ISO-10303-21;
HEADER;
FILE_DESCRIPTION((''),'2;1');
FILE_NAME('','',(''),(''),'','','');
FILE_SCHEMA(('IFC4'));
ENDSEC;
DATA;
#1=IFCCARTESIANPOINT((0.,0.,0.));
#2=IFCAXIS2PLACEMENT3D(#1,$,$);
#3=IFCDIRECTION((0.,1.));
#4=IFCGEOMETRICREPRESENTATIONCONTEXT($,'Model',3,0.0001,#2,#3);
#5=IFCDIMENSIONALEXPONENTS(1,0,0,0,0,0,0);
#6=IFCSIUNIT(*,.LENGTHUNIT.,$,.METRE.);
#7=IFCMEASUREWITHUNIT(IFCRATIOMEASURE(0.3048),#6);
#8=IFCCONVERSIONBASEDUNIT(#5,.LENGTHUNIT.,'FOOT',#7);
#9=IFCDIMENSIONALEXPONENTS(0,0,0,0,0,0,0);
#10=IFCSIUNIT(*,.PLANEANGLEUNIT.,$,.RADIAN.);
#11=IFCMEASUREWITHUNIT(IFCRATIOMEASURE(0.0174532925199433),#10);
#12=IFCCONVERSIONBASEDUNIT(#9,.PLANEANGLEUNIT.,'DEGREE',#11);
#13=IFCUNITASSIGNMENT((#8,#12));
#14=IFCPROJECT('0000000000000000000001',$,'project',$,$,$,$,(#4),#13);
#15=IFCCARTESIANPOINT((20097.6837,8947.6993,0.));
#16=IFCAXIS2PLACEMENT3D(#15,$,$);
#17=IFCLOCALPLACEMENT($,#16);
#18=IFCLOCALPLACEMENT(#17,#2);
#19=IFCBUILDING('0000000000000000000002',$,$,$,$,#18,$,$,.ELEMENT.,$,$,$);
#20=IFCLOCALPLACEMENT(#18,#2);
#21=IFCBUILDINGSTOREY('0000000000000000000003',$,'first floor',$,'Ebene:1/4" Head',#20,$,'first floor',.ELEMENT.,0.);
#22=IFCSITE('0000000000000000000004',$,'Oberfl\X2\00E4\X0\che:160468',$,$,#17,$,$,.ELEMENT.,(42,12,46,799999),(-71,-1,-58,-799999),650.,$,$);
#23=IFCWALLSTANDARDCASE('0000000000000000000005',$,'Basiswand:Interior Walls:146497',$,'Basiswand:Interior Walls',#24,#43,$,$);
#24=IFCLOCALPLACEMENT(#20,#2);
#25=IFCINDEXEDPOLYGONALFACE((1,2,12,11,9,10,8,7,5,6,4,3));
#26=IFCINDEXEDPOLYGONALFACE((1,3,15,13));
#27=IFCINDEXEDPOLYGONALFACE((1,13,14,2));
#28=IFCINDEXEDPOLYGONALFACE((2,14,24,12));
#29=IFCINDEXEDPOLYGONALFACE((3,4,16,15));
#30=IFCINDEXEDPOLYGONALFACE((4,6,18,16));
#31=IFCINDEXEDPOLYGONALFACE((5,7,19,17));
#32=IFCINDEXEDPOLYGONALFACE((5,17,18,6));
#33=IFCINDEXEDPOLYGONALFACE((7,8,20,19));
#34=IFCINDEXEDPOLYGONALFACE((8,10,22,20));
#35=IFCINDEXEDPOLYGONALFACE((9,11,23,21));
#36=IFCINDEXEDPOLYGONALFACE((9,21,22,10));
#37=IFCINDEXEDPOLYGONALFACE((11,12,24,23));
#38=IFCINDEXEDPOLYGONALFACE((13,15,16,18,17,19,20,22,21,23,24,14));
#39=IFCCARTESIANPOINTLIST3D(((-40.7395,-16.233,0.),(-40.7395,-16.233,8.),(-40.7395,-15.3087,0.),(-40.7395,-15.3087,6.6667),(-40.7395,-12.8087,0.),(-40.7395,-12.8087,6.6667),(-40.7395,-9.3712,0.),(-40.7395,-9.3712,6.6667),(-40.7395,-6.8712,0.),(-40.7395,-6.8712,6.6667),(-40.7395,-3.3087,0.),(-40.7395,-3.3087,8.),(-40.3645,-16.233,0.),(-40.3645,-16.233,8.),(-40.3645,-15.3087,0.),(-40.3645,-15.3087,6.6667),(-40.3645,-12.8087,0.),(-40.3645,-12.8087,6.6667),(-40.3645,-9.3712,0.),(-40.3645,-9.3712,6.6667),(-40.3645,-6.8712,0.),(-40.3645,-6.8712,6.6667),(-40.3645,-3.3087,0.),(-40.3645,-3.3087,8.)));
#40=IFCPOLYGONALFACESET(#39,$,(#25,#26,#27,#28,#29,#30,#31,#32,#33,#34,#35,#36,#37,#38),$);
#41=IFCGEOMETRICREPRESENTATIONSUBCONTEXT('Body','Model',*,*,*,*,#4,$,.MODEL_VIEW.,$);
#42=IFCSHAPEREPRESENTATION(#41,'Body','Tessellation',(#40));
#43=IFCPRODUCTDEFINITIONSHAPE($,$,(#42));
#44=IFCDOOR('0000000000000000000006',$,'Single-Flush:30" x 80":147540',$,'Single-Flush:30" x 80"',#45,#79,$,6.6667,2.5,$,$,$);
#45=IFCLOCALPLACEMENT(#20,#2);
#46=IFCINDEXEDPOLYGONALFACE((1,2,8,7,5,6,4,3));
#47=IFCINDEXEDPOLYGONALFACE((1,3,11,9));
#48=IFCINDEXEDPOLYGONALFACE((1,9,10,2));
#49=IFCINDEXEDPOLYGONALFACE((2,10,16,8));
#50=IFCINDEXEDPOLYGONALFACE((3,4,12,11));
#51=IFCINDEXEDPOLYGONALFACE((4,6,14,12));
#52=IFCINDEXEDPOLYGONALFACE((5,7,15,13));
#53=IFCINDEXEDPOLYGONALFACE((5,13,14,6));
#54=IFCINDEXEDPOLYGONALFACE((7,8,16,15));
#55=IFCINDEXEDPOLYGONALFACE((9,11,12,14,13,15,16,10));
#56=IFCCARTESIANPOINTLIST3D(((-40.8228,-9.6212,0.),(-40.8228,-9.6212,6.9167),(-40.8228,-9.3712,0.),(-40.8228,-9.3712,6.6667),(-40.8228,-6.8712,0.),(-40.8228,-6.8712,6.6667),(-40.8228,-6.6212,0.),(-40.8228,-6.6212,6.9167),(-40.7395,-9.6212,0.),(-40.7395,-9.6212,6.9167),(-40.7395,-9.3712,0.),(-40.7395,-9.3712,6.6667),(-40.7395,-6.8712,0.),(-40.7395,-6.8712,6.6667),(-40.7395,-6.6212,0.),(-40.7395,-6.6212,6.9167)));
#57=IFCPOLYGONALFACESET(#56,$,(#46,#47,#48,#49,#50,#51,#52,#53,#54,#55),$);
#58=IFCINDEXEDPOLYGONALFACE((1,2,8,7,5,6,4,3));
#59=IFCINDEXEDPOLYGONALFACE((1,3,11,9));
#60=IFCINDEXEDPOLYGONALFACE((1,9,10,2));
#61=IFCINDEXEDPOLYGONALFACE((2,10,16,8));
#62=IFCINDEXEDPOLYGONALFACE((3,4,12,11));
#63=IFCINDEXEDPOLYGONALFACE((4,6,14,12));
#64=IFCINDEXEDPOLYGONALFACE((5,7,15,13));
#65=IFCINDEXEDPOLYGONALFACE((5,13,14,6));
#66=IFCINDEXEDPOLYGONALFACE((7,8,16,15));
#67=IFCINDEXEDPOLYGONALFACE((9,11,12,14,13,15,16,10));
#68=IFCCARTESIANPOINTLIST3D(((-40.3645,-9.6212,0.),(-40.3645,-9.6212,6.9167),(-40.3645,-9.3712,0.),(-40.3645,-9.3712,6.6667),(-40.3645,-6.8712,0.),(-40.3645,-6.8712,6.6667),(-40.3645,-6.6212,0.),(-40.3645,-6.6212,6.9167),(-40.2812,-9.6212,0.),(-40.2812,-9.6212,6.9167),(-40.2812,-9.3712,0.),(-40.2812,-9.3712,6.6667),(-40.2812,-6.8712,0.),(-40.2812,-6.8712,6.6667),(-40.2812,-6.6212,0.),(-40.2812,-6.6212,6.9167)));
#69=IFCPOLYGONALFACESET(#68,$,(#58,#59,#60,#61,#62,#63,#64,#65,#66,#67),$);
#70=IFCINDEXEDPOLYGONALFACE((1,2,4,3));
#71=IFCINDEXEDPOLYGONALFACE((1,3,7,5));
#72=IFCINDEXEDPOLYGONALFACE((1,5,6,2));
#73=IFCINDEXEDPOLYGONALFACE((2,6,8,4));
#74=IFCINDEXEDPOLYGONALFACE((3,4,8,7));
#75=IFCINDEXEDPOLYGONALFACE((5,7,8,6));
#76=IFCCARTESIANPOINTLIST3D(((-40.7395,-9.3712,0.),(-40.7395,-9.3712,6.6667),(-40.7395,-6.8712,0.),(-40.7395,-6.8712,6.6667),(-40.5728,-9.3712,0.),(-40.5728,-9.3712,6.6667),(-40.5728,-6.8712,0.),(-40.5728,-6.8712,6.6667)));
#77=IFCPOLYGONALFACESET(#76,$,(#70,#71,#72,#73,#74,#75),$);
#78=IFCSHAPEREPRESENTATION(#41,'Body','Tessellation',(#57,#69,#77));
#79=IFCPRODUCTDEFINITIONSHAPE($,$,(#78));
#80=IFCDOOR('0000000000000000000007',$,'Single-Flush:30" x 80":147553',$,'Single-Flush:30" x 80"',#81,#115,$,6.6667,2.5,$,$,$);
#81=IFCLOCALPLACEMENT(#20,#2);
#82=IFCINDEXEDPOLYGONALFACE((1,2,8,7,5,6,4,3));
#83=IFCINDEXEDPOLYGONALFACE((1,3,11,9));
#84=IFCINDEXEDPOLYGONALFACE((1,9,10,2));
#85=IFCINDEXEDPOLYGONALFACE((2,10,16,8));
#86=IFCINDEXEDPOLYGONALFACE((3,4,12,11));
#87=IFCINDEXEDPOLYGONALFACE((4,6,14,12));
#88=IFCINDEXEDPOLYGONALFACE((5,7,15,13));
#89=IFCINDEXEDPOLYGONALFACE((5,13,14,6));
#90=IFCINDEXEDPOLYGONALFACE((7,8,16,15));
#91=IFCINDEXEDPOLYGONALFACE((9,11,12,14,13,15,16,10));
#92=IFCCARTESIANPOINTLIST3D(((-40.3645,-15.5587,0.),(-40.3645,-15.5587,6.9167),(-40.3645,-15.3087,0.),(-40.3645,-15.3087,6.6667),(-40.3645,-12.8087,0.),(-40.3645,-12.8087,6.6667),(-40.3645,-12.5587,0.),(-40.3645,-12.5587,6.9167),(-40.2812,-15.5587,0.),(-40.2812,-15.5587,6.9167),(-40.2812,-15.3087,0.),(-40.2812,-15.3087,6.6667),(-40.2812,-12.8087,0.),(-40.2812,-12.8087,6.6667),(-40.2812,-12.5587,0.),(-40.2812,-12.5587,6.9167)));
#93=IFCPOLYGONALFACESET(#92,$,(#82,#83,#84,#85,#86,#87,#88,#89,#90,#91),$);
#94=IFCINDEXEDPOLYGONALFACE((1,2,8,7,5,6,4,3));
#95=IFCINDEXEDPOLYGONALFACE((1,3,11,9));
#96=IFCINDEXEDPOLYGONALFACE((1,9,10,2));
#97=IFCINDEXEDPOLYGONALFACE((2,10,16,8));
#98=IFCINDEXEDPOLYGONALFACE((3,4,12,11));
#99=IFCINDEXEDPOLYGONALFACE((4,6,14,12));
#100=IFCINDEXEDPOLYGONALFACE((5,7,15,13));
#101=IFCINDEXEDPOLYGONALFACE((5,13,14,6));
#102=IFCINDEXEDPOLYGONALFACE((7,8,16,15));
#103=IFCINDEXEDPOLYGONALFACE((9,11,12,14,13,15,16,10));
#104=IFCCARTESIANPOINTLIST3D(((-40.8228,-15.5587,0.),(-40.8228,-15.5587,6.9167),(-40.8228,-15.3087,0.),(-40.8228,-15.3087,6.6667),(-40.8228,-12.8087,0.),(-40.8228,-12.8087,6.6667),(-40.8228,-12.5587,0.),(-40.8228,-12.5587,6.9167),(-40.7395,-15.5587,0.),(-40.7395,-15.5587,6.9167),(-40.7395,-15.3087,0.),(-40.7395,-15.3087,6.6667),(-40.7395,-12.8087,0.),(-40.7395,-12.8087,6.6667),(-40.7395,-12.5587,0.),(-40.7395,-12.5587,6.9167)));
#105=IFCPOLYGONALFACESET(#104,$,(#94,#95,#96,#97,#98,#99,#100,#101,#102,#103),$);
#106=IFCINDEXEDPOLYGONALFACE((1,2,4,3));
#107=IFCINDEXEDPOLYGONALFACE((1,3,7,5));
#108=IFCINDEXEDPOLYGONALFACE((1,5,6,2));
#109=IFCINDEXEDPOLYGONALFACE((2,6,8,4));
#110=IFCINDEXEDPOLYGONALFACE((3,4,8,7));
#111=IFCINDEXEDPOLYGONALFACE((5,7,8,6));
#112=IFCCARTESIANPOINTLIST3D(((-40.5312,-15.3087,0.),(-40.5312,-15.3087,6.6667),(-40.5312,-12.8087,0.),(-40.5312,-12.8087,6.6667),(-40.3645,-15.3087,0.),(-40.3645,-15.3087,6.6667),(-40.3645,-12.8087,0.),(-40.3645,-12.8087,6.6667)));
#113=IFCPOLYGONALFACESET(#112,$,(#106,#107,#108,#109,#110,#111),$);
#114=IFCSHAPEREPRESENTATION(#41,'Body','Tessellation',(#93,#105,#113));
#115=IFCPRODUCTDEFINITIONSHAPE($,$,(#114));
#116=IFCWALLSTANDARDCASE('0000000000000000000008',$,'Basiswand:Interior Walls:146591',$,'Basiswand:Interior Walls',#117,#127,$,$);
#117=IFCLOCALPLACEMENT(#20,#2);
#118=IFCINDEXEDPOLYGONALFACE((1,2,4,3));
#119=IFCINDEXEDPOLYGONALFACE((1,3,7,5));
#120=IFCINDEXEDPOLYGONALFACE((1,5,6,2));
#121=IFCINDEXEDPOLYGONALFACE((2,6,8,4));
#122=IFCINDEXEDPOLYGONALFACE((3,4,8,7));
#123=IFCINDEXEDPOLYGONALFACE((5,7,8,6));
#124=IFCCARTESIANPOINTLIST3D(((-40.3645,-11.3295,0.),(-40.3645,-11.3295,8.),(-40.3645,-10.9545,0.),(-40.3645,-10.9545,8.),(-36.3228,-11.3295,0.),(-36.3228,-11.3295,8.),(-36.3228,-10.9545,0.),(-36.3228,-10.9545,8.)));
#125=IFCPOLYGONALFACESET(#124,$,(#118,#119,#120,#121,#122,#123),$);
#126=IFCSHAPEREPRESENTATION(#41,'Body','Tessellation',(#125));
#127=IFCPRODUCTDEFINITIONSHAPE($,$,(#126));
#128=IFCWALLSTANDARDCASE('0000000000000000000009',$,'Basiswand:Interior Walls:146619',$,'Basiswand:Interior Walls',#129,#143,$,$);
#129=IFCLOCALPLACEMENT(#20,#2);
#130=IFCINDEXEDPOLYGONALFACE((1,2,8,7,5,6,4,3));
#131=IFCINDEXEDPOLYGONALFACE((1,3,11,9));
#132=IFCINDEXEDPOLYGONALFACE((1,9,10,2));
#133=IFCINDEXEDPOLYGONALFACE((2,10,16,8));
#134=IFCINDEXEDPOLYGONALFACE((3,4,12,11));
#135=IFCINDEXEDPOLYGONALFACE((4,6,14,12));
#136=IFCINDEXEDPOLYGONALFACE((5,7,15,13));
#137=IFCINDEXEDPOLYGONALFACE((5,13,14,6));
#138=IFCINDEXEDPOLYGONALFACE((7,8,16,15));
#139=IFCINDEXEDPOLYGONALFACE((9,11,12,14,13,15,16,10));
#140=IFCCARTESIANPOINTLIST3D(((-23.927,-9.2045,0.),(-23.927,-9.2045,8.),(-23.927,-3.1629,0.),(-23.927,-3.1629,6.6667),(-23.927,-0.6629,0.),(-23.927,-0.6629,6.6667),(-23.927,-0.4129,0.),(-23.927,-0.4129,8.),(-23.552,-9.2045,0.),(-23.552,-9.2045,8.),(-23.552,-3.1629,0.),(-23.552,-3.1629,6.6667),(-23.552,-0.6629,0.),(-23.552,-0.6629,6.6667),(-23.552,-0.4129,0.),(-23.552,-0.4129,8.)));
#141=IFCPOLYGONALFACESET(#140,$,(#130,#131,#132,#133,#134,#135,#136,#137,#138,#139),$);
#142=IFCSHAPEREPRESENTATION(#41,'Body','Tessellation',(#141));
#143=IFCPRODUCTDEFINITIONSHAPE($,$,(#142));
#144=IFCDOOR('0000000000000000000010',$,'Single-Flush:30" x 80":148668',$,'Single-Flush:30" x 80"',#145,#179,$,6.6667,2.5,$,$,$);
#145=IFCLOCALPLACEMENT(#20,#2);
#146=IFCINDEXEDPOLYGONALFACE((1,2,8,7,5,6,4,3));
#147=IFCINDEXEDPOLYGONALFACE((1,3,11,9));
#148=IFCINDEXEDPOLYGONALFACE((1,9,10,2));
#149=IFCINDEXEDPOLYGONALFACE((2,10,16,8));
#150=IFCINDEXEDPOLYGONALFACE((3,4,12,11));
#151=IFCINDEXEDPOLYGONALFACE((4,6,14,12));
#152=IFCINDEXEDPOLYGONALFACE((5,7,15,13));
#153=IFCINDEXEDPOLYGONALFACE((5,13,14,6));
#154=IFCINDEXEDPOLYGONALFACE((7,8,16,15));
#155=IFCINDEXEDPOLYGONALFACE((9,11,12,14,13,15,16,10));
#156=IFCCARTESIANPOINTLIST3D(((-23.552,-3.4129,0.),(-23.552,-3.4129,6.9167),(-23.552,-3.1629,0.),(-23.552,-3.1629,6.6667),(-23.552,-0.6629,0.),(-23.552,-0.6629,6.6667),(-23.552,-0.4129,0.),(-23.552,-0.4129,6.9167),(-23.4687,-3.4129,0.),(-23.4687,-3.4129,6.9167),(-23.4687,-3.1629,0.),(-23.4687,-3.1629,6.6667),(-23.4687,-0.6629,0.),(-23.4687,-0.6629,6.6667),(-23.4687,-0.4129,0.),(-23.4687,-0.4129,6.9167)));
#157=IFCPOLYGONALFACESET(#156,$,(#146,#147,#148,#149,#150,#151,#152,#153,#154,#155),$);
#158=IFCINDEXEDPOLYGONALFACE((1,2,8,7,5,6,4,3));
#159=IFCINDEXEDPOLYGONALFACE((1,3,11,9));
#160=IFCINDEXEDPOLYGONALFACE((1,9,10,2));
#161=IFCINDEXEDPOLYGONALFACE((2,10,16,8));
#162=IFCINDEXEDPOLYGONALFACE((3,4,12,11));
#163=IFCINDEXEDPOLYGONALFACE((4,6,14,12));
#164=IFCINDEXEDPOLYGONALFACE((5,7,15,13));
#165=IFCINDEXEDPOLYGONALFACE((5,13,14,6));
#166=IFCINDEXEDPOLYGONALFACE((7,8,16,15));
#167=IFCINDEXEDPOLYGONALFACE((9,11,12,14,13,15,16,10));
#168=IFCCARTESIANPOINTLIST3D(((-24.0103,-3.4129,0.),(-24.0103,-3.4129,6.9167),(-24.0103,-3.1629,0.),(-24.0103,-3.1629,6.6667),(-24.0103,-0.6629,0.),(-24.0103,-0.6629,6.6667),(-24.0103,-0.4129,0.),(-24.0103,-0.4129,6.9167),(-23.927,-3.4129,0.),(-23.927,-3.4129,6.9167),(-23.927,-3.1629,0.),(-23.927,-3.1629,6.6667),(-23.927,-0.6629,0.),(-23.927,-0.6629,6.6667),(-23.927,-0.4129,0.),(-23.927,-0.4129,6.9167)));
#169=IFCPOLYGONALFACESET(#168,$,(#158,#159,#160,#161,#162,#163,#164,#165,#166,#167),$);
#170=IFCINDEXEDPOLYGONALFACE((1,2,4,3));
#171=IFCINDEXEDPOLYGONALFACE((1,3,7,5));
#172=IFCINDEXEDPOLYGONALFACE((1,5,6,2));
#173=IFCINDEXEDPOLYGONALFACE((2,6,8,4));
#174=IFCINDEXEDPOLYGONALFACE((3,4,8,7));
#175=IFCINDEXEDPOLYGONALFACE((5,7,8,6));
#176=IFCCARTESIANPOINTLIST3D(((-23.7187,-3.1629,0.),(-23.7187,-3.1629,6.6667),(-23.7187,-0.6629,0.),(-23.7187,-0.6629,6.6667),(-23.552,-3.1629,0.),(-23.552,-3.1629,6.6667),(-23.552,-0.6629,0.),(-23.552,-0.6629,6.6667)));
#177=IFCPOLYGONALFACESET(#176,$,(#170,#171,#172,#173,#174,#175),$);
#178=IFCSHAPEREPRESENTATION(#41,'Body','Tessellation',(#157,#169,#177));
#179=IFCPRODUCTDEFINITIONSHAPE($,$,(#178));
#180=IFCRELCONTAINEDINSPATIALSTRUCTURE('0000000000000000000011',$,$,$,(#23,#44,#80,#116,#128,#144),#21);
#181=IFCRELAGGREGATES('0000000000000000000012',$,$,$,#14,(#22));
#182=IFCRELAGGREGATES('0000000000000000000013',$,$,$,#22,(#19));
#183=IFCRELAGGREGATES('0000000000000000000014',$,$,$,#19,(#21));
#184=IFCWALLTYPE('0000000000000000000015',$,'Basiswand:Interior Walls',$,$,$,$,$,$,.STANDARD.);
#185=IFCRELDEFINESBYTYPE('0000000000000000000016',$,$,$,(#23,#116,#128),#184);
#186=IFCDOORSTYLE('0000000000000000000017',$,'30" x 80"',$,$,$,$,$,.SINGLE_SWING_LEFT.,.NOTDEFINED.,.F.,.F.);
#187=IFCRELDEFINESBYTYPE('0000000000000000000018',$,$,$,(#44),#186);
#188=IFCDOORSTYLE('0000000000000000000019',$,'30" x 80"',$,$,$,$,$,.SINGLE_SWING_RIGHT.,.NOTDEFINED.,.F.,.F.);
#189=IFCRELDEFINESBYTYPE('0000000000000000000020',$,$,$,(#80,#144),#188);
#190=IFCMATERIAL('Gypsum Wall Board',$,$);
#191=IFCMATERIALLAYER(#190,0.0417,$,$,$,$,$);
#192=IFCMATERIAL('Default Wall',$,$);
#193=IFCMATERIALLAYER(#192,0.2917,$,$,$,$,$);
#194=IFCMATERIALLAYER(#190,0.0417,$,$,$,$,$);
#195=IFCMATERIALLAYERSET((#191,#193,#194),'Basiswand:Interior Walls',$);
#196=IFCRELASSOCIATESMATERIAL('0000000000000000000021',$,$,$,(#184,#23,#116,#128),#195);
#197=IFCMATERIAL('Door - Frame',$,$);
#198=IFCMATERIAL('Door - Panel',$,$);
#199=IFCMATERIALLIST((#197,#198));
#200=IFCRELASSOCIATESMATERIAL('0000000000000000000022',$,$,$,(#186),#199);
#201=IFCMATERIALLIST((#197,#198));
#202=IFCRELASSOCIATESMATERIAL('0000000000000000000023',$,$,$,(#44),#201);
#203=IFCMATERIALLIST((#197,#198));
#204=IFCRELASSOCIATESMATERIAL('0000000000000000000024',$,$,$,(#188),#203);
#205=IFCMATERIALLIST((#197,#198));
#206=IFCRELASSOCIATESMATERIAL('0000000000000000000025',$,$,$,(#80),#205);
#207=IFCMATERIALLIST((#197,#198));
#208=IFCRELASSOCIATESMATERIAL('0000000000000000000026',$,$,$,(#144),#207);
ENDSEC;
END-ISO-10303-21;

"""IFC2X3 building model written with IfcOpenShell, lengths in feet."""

from ifc_helpers import new_model, entity, si_unit, converted_unit, direction, frame, frame_2d, origin, origin_2d_with_axis, place, context, subcontext, project, spatial, polyline, rectangle, outline, extrude, source, transform, mapped, material, material_list, layer, layer_set, layer_usage, type_object, type_shapes, element, fill, save


model = new_model("IFC2X3")

# Units and contexts
model_context = context("Model", 3, precision=0.0001, world=origin(), true_north=direction((0.0, 1.0)))
body_context = subcontext(model_context, "Body", "Model", "MODEL_VIEW")
ifc_project = project(units=[converted_unit("LENGTHUNIT", "FOOT", entity("IfcRatioMeasure", 0.3048), si_unit("LENGTHUNIT", "METRE"), dimensions=[1, 0, 0, 0, 0, 0, 0]), converted_unit("PLANEANGLEUNIT", "DEGREE", entity("IfcRatioMeasure", 0.0174532925199433), si_unit("PLANEANGLEUNIT", "RADIAN"), dimensions=[0, 0, 0, 0, 0, 0, 0])], contexts=[model_context])

# Site, building, storey
site_placement = place(None, frame((20097.6837, 8947.6993, 0.0)))
site = spatial("IfcSite", under=ifc_project, at=site_placement, Name="Oberfläche:160468", CompositionType="ELEMENT", RefLatitude=(42, 12, 46, 799999), RefLongitude=(-71, -1, -58, -799999), RefElevation=650.0)
building_placement = place(site_placement, origin())
building = spatial("IfcBuilding", under=site, at=building_placement, CompositionType="ELEMENT")
storey_placement = place(building_placement, origin())
storey = spatial("IfcBuildingStorey", under=building, at=storey_placement, Name="first floor", ObjectType="Ebene:1/4\" Head", LongName="first floor", CompositionType="ELEMENT", Elevation=0.0)

# Shared definitions
ifc_material_1 = material(Name="Gypsum Wall Board")

# Shared definitions
ifc_material_2 = material(Name="Door - Frame")

# Shared definitions
ifc_material_3 = material(Name="Door - Panel")

# Wall, openings, doors
ifc_layer_1 = layer(ifc_material_1, 0.0417)
ifc_material_4 = material(Name="Default Wall")
ifc_layer_2 = layer(ifc_material_4, 0.2917)
ifc_layer_3 = layer(ifc_material_1, 0.0417)
ifc_layer_set_1 = layer_set([ifc_layer_1, ifc_layer_2, ifc_layer_3], Name="Basiswand:Interior Walls")
ifc_layer_usage_1 = layer_usage(ifc_layer_set_1, "AXIS2", "NEGATIVE", 0.1875)
wall_type_1 = type_object("IfcWallType", Name="Basiswand:Interior Walls", PredefinedType="STANDARD", material=ifc_layer_set_1)
wall_1_placement = place(storey_placement, frame((-40.552, -3.3087, 0.0), z_axis=(0.0, 0.0, 1.0), x_axis=(0.0, -1.0, 0.0)))
wall_1 = element("IfcWallStandardCase", 1, at=wall_1_placement, inside=storey, type_object=wall_type_1, material=ifc_layer_usage_1, Name="Basiswand:Interior Walls:146497", ObjectType="Basiswand:Interior Walls", context=body_context, shape_type="SweptSolid", body=[
    extrude(rectangle(XDim=12.9243, YDim=0.375, at=frame_2d((6.4621, 0.0), x_axis=(-1.0, 0.0))), origin(), (0.0, 0.0, 1.0), 8.0),
])
opening_1_placement = place(wall_1_placement, frame((6.0625, 0.1875, 0.0)))
opening_1 = element("IfcOpeningElement", 2, at=opening_1_placement, cuts=wall_1, ObjectType="Opening", context=body_context, shape_type="SweptSolid", body=[
    extrude(rectangle(XDim=2.5, YDim=6.6667, at=frame_2d((3.3333, 1.25), x_axis=(0.0, -1.0))), frame((0.0, 0.0, 0.0), z_axis=(0.0, -1.0, 0.0), x_axis=(0.0, 0.0, 1.0)), (0.0, 0.0, 1.0), 0.375),
])
opening_2_placement = place(wall_1_placement, frame((9.5, -0.1875, 0.0)))
opening_2 = element("IfcOpeningElement", 3, at=opening_2_placement, cuts=wall_1, ObjectType="Opening", context=body_context, shape_type="SweptSolid", body=[
    extrude(rectangle(XDim=2.5, YDim=6.6667, at=frame_2d((3.3333, 1.25), x_axis=(0.0, 1.0))), frame((0.0, 0.0, 0.0), z_axis=(0.0, 1.0, 0.0), x_axis=(0.0, 0.0, 1.0)), (0.0, 0.0, 1.0), 0.375),
])
ifc_material_list_1 = material_list([ifc_material_2, ifc_material_3])
ifc_material_list_2 = material_list([ifc_material_2, ifc_material_3])
door_style_1 = type_object("IfcDoorStyle", Name="30\" x 80\"", ConstructionType="NOTDEFINED", OperationType="SINGLE_SWING_LEFT", ParameterTakesPrecedence=False, Sizeable=False, material=ifc_material_list_2)
shared_shape_1 = source(origin(), body_context, "Body", "SweptSolid", [
    extrude(outline(polyline([(-1.5, -3.5208), (1.5, -3.5208), (1.5, 3.3958), (1.25, 3.3958), (1.25, -3.2708), (-1.25, -3.2708), (-1.25, 3.3958), (-1.5, 3.3958), (-1.5, -3.5208)])), frame((1.25, 0.4583, 3.3958), z_axis=(0.0, -1.0, 0.0), x_axis=(-1.0, 0.0, 0.0)), (0.0, 0.0, 1.0), 0.0833),
    extrude(outline(polyline([(-3.5208, -1.5), (3.3958, -1.5), (3.3958, -1.25), (-3.2708, -1.25), (-3.2708, 1.25), (3.3958, 1.25), (3.3958, 1.5), (-3.5208, 1.5), (-3.5208, -1.5)])), frame((1.25, 0.0, 3.3958), z_axis=(0.0, -1.0, 0.0), x_axis=(0.0, 0.0, -1.0)), (0.0, 0.0, 1.0), 0.0833),
    extrude(rectangle(XDim=2.5, YDim=0.1667, at=origin_2d_with_axis()), frame((1.25, 0.2917, 0.0)), (0.0, 0.0, 1.0), 6.6667),
])
type_shapes(door_style_1, [shared_shape_1])
door_1_placement = place(opening_1_placement, frame((0.0, 0.0, 0.0), z_axis=(0.0, 0.0, 1.0), x_axis=(-1.0, 0.0, 0.0)))
door_1 = element("IfcDoor", 4, at=door_1_placement, inside=storey, type_object=door_style_1, material=ifc_material_list_1, Name="Single-Flush:30\" x 80\":147540", ObjectType="Single-Flush:30\" x 80\"", OverallHeight=6.6667, OverallWidth=2.5, context=body_context, shape_type="MappedRepresentation", body=[
    mapped(shared_shape_1, transform((0.0, 0.0, 0.0), scale=1.0)),
])
fill(opening_1, door_1)
ifc_material_list_3 = material_list([ifc_material_2, ifc_material_3])
ifc_material_list_4 = material_list([ifc_material_2, ifc_material_3])
door_style_2 = type_object("IfcDoorStyle", Name="30\" x 80\"", ConstructionType="NOTDEFINED", OperationType="SINGLE_SWING_RIGHT", ParameterTakesPrecedence=False, Sizeable=False, material=ifc_material_list_4)
shared_shape_2 = source(origin(), body_context, "Body", "SweptSolid", [
    extrude(outline(polyline([(-1.5, -3.5208), (1.5, -3.5208), (1.5, 3.3958), (1.25, 3.3958), (1.25, -3.2708), (-1.25, -3.2708), (-1.25, 3.3958), (-1.5, 3.3958), (-1.5, -3.5208)])), frame((1.25, 0.375, 3.3958), z_axis=(0.0, 1.0, 0.0), x_axis=(1.0, 0.0, 0.0)), (0.0, 0.0, 1.0), 0.0833),
    extrude(outline(polyline([(-3.5208, -1.5), (3.3958, -1.5), (3.3958, -1.25), (-3.2708, -1.25), (-3.2708, 1.25), (3.3958, 1.25), (3.3958, 1.5), (-3.5208, 1.5), (-3.5208, -1.5)])), frame((1.25, -0.0833, 3.3958), z_axis=(0.0, 1.0, 0.0), x_axis=(0.0, 0.0, -1.0)), (0.0, 0.0, 1.0), 0.0833),
    extrude(rectangle(XDim=0.1667, YDim=2.5, at=origin_2d_with_axis()), frame((1.25, 0.2917, 0.0), z_axis=(0.0, 0.0, 1.0), x_axis=(0.0, 1.0, 0.0)), (0.0, 0.0, 1.0), 6.6667),
])
type_shapes(door_style_2, [shared_shape_2])
door_2_placement = place(opening_2_placement, origin())
door_2 = element("IfcDoor", 5, at=door_2_placement, inside=storey, type_object=door_style_2, material=ifc_material_list_3, Name="Single-Flush:30\" x 80\":147553", ObjectType="Single-Flush:30\" x 80\"", OverallHeight=6.6667, OverallWidth=2.5, context=body_context, shape_type="MappedRepresentation", body=[
    mapped(shared_shape_2, transform((0.0, 0.0, 0.0), scale=1.0)),
])
fill(opening_2, door_2)

# Wall
ifc_layer_usage_2 = layer_usage(ifc_layer_set_1, "AXIS2", "NEGATIVE", 0.1875)
wall_2_placement = place(storey_placement, frame((-40.3645, -11.142, 0.0)))
element("IfcWallStandardCase", 6, at=wall_2_placement, inside=storey, type_object=wall_type_1, material=ifc_layer_usage_2, Name="Basiswand:Interior Walls:146591", ObjectType="Basiswand:Interior Walls", context=body_context, shape_type="SweptSolid", body=[
    extrude(rectangle(XDim=4.0417, YDim=0.375, at=frame_2d((2.0208, 0.0), x_axis=(-1.0, 0.0))), origin(), (0.0, 0.0, 1.0), 8.0),
])

# Wall, opening, door
ifc_layer_usage_3 = layer_usage(ifc_layer_set_1, "AXIS2", "NEGATIVE", 0.1875)
wall_3_placement = place(storey_placement, frame((-23.7395, -0.4129, 0.0), z_axis=(0.0, 0.0, 1.0), x_axis=(0.0, -1.0, 0.0)))
wall_3 = element("IfcWallStandardCase", 7, at=wall_3_placement, inside=storey, type_object=wall_type_1, material=ifc_layer_usage_3, Name="Basiswand:Interior Walls:146619", ObjectType="Basiswand:Interior Walls", context=body_context, shape_type="SweptSolid", body=[
    extrude(rectangle(XDim=8.7917, YDim=0.375, at=frame_2d((4.3958, 0.0), x_axis=(-1.0, 0.0))), origin(), (0.0, 0.0, 1.0), 8.0),
])
opening_3_placement = place(wall_3_placement, frame((0.25, -0.1875, 0.0)))
opening_3 = element("IfcOpeningElement", 8, at=opening_3_placement, cuts=wall_3, ObjectType="Opening", context=body_context, shape_type="SweptSolid", body=[
    extrude(rectangle(XDim=2.5, YDim=6.6667, at=frame_2d((3.3333, 1.25), x_axis=(0.0, 1.0))), frame((0.0, 0.0, 0.0), z_axis=(0.0, 1.0, 0.0), x_axis=(0.0, 0.0, 1.0)), (0.0, 0.0, 1.0), 0.375),
])
ifc_material_list_5 = material_list([ifc_material_2, ifc_material_3])
door_3_placement = place(opening_3_placement, origin())
door_3 = element("IfcDoor", 9, at=door_3_placement, inside=storey, type_object=door_style_2, material=ifc_material_list_5, Name="Single-Flush:30\" x 80\":148668", ObjectType="Single-Flush:30\" x 80\"", OverallHeight=6.6667, OverallWidth=2.5, context=body_context, shape_type="MappedRepresentation", body=[
    mapped(shared_shape_2, transform((0.0, 0.0, 0.0), scale=1.0)),
])
fill(opening_3, door_3)

save(model, "model.ifc")
